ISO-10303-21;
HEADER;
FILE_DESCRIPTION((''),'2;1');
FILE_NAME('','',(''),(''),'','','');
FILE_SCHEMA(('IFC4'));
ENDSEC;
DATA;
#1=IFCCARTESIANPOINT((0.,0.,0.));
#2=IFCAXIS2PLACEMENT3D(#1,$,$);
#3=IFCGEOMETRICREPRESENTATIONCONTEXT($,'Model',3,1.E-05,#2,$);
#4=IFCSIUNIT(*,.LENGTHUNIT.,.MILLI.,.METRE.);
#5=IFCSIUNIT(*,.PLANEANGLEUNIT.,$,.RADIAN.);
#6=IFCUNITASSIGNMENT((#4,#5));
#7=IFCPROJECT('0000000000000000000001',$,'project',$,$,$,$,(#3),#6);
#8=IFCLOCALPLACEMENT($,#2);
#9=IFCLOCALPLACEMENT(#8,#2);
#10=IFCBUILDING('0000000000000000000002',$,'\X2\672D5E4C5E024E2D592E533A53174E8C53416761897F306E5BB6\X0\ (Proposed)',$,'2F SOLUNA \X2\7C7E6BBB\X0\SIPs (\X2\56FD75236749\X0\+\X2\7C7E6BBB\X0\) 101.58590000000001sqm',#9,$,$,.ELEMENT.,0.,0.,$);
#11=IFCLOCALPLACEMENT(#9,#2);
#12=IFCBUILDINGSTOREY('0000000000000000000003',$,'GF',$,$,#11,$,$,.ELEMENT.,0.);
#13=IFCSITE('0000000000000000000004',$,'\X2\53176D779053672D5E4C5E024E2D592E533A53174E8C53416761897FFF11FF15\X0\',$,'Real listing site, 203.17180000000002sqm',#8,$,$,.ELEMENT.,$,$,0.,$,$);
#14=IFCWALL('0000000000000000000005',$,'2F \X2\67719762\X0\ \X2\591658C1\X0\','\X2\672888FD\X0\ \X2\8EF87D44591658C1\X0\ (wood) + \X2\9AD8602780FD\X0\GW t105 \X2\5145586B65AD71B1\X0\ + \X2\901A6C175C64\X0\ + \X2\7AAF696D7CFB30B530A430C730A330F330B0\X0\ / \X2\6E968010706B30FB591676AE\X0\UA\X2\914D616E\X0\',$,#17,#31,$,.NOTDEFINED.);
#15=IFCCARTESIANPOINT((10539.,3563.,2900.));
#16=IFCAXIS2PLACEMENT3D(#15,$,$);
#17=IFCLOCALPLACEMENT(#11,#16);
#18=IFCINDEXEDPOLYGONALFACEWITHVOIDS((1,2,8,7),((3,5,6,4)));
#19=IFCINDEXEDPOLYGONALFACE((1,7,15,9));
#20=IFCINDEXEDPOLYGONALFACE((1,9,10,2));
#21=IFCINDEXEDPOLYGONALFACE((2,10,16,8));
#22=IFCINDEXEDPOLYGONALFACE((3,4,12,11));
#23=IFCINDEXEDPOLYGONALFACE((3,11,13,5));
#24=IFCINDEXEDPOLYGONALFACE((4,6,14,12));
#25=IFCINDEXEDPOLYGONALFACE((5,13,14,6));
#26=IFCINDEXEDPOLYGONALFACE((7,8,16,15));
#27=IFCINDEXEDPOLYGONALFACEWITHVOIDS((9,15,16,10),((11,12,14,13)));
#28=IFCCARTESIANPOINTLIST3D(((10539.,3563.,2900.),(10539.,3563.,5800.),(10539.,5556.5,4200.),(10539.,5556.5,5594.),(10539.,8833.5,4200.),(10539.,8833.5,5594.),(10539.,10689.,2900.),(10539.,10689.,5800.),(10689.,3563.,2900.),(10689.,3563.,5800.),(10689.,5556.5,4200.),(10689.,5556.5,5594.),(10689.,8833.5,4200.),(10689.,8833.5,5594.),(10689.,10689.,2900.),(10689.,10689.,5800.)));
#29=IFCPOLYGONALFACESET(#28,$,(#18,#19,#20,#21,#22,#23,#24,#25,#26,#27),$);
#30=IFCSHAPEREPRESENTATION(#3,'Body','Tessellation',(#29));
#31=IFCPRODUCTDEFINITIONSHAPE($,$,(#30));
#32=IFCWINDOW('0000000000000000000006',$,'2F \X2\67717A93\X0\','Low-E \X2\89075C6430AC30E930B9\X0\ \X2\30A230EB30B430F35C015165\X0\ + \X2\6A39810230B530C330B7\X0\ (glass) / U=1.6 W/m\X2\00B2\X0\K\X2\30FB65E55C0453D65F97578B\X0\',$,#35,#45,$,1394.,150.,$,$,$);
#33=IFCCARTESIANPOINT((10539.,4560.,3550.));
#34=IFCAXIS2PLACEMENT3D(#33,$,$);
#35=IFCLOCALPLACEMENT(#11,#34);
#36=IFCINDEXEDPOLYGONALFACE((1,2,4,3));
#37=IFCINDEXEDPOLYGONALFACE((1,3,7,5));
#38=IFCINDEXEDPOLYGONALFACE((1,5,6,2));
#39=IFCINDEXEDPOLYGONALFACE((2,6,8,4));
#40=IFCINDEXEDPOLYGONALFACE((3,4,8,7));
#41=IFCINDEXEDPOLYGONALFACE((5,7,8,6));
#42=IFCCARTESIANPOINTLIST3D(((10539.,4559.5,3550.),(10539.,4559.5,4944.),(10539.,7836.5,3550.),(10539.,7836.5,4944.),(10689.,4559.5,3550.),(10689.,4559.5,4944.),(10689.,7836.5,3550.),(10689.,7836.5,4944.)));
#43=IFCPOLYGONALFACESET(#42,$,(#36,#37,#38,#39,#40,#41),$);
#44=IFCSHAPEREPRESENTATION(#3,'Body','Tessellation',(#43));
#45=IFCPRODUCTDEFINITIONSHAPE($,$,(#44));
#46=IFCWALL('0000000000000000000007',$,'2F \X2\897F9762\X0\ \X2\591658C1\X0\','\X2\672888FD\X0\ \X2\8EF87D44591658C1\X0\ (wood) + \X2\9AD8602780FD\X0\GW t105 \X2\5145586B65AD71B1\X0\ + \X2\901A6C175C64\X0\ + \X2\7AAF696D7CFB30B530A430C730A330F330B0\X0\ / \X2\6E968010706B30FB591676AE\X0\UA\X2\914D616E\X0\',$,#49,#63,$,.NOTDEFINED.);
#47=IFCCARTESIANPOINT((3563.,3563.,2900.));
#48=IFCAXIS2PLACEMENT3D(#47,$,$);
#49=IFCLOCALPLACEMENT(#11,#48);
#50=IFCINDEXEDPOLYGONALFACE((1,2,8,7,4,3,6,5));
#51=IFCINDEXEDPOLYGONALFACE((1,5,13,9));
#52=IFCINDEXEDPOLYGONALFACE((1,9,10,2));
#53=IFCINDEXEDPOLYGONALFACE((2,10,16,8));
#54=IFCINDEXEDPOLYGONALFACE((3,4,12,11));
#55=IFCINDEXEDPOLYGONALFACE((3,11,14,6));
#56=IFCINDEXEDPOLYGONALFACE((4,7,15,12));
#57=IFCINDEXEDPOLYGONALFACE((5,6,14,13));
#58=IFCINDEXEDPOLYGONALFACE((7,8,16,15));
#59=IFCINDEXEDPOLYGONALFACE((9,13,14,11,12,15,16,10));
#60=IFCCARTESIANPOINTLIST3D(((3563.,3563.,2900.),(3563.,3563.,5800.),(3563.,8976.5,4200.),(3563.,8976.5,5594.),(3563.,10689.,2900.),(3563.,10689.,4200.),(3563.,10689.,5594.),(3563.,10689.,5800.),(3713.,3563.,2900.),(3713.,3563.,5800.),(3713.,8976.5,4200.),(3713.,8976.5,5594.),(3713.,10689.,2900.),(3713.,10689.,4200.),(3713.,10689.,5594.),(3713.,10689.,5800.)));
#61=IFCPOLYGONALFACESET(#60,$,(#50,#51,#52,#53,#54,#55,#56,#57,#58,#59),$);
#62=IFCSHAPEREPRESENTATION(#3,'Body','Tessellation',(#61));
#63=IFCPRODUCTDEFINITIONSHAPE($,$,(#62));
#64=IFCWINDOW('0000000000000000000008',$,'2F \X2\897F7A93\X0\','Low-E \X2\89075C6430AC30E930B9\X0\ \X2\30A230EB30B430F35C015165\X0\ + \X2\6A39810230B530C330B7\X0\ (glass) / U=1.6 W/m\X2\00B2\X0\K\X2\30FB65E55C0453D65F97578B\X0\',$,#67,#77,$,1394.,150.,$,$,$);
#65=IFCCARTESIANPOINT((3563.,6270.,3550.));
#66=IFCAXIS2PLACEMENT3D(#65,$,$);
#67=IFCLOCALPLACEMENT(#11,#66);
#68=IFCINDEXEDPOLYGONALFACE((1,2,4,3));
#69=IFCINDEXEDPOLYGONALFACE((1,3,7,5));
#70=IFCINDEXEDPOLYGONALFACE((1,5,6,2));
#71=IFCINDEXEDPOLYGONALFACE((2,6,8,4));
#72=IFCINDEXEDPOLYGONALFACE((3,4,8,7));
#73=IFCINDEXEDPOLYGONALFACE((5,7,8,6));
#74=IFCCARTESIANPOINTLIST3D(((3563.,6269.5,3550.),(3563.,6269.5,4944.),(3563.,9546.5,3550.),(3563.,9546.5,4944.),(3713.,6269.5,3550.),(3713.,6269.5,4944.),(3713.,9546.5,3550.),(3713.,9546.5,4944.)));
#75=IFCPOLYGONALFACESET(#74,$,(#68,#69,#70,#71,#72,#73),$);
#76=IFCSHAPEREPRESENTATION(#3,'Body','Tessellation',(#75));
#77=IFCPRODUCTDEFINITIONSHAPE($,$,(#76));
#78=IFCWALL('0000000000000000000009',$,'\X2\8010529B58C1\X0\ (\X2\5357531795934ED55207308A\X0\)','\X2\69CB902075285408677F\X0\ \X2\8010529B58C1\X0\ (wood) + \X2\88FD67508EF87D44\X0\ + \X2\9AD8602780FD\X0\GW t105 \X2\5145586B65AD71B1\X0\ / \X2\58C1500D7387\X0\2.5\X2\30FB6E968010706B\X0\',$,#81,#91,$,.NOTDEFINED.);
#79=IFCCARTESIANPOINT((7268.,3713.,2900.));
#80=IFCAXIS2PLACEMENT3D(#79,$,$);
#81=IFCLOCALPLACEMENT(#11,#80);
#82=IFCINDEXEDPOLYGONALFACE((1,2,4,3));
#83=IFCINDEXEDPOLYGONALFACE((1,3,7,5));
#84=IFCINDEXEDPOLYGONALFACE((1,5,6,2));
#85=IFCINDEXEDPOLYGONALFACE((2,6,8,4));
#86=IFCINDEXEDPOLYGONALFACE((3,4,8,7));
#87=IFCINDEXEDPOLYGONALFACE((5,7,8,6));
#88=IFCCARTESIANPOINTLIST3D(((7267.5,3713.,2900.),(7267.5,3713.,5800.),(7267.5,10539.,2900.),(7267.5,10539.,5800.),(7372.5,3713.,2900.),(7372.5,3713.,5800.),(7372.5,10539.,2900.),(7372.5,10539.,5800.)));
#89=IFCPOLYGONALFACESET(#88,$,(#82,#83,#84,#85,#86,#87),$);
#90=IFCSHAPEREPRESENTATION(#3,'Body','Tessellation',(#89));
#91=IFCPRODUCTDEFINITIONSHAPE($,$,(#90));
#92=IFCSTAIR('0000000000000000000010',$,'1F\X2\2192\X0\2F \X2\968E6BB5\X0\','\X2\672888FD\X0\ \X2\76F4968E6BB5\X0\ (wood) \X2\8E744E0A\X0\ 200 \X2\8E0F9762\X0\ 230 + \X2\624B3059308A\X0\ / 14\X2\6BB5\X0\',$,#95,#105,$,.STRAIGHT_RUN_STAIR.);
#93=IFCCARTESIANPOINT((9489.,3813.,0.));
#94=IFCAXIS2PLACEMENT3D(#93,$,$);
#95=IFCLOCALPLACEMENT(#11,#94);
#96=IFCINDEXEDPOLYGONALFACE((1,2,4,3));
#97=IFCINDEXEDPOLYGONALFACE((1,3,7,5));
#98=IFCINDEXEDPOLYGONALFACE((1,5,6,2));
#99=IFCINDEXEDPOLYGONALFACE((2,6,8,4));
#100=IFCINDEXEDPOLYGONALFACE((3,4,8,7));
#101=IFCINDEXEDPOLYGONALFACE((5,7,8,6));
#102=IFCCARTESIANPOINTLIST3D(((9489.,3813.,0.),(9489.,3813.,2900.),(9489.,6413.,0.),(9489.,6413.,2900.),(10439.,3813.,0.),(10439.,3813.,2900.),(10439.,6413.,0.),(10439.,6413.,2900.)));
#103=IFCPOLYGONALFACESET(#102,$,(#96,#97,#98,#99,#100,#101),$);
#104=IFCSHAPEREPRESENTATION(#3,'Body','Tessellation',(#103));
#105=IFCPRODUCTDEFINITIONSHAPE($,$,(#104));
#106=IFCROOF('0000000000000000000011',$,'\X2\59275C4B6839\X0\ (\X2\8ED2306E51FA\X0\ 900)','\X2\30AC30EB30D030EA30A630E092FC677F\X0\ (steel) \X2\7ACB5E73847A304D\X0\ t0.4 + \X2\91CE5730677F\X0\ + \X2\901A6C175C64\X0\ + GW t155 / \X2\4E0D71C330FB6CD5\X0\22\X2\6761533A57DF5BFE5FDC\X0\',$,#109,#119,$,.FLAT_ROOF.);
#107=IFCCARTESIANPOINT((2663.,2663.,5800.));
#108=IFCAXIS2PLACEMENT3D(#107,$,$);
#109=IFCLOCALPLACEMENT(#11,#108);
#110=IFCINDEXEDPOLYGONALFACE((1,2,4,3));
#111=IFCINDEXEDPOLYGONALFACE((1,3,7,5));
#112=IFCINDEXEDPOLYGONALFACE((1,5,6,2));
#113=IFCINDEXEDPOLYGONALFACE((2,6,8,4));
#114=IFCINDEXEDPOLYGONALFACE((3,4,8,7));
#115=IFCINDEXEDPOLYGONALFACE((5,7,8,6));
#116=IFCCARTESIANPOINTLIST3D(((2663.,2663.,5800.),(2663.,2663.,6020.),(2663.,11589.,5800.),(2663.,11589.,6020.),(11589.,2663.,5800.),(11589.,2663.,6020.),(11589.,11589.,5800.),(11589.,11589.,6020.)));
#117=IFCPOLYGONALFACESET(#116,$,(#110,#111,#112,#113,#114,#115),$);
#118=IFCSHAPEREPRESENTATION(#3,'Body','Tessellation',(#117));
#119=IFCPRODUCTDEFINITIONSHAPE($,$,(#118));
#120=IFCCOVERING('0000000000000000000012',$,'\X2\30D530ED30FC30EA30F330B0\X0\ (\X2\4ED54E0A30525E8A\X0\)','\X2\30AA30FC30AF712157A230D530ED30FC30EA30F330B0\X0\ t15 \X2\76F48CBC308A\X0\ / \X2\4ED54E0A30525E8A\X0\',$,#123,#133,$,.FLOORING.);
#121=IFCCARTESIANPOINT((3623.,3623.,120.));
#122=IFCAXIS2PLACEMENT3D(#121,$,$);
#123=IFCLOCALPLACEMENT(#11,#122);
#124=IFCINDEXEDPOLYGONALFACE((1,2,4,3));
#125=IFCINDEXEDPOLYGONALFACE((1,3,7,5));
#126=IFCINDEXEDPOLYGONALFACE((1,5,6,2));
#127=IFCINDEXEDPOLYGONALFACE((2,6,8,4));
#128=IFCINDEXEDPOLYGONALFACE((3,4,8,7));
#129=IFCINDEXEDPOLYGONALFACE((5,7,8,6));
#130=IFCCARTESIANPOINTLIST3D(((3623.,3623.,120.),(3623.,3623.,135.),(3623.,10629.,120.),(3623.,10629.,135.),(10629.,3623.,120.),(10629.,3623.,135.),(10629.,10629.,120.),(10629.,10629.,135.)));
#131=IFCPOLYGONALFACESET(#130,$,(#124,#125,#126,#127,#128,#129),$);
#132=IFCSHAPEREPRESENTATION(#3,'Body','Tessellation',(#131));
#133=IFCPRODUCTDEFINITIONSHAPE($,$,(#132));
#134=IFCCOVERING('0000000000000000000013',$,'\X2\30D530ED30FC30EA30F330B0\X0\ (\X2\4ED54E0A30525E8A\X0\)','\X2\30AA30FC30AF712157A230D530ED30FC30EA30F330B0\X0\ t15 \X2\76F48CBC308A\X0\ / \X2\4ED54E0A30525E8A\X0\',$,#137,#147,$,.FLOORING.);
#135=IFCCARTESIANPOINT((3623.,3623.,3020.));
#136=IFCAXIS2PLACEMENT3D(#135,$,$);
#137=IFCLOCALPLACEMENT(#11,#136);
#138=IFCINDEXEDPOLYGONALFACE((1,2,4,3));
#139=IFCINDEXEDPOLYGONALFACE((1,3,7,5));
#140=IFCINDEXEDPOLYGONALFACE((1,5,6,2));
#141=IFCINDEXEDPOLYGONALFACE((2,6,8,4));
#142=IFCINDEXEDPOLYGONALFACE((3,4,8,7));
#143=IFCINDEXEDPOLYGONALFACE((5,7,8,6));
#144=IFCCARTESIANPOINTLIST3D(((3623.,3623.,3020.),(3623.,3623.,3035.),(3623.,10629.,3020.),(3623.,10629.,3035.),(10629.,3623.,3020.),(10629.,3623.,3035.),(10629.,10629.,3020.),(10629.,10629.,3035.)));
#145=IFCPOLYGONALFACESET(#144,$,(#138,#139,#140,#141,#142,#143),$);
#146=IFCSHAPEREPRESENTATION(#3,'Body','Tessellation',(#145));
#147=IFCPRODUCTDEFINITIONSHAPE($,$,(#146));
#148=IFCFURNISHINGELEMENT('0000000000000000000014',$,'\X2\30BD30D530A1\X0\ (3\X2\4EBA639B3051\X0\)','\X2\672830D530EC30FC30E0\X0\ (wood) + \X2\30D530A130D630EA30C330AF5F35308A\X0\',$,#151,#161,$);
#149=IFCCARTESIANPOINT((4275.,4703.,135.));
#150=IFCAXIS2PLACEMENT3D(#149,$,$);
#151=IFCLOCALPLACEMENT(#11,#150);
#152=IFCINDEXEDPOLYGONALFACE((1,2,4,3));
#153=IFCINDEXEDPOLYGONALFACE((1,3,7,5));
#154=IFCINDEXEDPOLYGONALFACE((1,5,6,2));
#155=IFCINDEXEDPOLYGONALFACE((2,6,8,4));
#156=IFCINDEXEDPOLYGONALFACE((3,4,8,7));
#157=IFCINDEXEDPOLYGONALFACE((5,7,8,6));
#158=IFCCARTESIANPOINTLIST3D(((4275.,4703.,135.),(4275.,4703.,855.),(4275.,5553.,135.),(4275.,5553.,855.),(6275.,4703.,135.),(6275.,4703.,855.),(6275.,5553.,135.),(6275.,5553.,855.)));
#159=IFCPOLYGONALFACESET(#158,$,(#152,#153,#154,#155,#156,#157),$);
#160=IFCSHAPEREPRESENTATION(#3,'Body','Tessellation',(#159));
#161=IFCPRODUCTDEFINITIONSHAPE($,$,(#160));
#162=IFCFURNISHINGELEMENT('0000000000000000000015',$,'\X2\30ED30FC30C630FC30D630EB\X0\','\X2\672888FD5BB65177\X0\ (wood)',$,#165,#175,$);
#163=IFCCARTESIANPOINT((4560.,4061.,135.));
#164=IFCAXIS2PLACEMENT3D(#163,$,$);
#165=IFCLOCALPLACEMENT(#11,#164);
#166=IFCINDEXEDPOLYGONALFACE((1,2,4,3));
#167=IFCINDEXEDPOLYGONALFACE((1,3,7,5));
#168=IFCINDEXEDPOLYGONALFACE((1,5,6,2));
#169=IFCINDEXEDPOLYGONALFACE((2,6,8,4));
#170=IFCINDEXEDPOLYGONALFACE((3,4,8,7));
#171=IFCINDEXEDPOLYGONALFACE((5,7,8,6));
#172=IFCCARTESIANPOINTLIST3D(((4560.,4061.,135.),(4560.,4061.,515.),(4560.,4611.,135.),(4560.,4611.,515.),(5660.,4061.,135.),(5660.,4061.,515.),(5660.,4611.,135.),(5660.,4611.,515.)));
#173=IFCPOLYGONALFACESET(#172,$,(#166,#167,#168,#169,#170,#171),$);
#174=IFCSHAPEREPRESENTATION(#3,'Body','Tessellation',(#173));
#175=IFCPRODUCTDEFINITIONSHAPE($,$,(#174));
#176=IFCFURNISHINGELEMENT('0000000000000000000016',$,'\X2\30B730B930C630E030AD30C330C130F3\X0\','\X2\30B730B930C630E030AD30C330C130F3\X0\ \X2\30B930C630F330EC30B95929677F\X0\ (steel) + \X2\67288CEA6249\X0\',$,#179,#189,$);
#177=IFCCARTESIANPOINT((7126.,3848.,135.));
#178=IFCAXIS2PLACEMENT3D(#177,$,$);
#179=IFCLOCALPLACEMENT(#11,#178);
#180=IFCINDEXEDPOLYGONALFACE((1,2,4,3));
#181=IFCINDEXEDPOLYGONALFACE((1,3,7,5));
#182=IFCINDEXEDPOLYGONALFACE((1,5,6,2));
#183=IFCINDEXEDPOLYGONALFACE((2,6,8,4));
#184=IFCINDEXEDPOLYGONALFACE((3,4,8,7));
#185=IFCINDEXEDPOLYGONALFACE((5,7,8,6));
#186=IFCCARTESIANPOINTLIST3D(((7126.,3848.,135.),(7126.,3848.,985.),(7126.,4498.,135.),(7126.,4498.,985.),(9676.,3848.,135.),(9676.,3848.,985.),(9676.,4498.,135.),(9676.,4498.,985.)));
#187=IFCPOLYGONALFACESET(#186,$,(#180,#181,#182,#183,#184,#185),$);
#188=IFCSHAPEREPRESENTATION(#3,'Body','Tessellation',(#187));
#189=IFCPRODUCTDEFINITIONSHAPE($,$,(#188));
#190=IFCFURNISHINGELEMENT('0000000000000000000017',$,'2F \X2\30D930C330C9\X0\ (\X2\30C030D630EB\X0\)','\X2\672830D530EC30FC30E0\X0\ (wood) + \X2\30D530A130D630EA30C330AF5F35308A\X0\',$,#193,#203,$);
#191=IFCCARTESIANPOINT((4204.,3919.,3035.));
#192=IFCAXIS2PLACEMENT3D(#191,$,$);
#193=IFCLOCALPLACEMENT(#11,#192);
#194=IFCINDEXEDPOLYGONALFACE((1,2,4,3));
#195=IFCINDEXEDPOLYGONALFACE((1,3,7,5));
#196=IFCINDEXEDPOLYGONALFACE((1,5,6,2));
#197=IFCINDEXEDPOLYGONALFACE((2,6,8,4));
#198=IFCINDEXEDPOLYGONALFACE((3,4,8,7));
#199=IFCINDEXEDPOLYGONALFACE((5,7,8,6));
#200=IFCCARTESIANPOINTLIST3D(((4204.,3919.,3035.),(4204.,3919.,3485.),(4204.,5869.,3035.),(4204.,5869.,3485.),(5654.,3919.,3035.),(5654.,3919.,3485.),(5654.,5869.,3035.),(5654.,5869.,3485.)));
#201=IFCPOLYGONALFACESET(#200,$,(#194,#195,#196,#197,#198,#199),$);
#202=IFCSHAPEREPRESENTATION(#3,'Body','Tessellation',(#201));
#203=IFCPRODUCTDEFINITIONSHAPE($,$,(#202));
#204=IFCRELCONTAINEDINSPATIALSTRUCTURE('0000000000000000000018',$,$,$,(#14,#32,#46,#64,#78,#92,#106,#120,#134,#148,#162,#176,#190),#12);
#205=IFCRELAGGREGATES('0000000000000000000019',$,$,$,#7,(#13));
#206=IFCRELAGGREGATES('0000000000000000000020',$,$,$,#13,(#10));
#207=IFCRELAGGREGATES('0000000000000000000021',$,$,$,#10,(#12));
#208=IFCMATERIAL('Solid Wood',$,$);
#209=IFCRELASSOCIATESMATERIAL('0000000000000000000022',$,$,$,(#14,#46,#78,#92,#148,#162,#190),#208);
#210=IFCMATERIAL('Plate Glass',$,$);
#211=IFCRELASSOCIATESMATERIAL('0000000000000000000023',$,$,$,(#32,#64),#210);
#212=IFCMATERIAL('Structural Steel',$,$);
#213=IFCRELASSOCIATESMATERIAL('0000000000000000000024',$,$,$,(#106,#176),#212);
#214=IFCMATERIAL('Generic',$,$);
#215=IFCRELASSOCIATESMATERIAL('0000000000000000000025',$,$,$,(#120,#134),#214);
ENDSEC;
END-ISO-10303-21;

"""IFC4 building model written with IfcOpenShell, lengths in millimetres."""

from ifc_helpers import new_model, si_unit, frame, frame_2d, origin, place, context, project, spatial, rectangle, extrude, material, element, fill, save


model = new_model("IFC4")

# Units and contexts
model_context = context("Model", 3, precision=1e-05, world=origin())
ifc_project = project(units=[si_unit("LENGTHUNIT", "METRE", prefix="MILLI"), si_unit("PLANEANGLEUNIT", "RADIAN")], contexts=[model_context])

# Site, building, storey
site_placement = place(None, origin())
site = spatial("IfcSite", under=ifc_project, at=site_placement, Name="北海道札幌市中央区北二十条西１５", ObjectType="Real listing site, 203.17180000000002sqm", CompositionType="ELEMENT", RefElevation=0.0)
building_placement = place(site_placement, origin())
building = spatial("IfcBuilding", under=site, at=building_placement, Name="札幌市中央区北二十条西の家 (Proposed)", ObjectType="2F SOLUNA 籾殻SIPs (国産杉+籾殻) 101.58590000000001sqm", CompositionType="ELEMENT", ElevationOfRefHeight=0.0, ElevationOfTerrain=0.0)
storey_placement = place(building_placement, origin())
storey = spatial("IfcBuildingStorey", under=building, at=storey_placement, Name="GF", CompositionType="ELEMENT", Elevation=0.0)

# Shared definitions
ifc_material_1 = material(Name="Solid Wood")

# Shared definitions
ifc_material_2 = material(Name="Plate Glass")

# Walls, openings, windows
wall_1_placement = place(storey_placement, frame((10539.0, 3563.0, 2900.0)))
wall_1 = element("IfcWall", 1, at=wall_1_placement, inside=storey, material=ifc_material_1, Name="2F 東面 外壁", Description="木製 軸組外壁 (wood) + 高性能GW t105 充填断熱 + 通気層 + 窯業系サイディング / 準耐火・外皮UA配慮", PredefinedType="NOTDEFINED", context=model_context, shape_type="SweptSolid", body=[
    extrude(rectangle(XDim=150.0, YDim=7126.0, at=frame_2d((75.0, 3563.0))), frame((10539.0, 3563.0, 2900.0)), (0.0, 0.0, 1.0), 2900.0),
])
opening_1_placement = place(storey_placement, frame((10539.0, 4560.0, 3550.0)))
opening_1 = element("IfcOpeningElement", 2, at=opening_1_placement, cuts=wall_1, PredefinedType="NOTDEFINED", context=model_context, shape_type="SweptSolid", body=[
    extrude(rectangle(XDim=150.0, YDim=3277.0, at=frame_2d((75.0, 1638.0))), frame((10539.0, 4560.0, 3550.0)), (0.0, 0.0, 1.0), 1394.0),
])
window_1_placement = place(storey_placement, frame((10539.0, 4560.0, 3550.0)))
window_1 = element("IfcWindow", 3, at=window_1_placement, inside=storey, material=ifc_material_2, Name="2F 東窓", Description="Low-E 複層ガラス アルゴン封入 + 樹脂サッシ (glass) / U=1.6 W/m²K・日射取得型", OverallHeight=1394.0, OverallWidth=150.0, context=model_context, shape_type="SweptSolid", body=[
    extrude(rectangle(XDim=150.0, YDim=3277.0, at=frame_2d((75.0, 1638.0))), frame((10539.0, 4560.0, 3550.0)), (0.0, 0.0, 1.0), 1394.0),
])
fill(opening_1, window_1)
wall_2_placement = place(storey_placement, frame((3563.0, 3563.0, 2900.0)))
wall_2 = element("IfcWall", 4, at=wall_2_placement, inside=storey, material=ifc_material_1, Name="2F 西面 外壁", Description="木製 軸組外壁 (wood) + 高性能GW t105 充填断熱 + 通気層 + 窯業系サイディング / 準耐火・外皮UA配慮", PredefinedType="NOTDEFINED", context=model_context, shape_type="SweptSolid", body=[
    extrude(rectangle(XDim=150.0, YDim=7126.0, at=frame_2d((75.0, 3563.0))), frame((3563.0, 3563.0, 2900.0)), (0.0, 0.0, 1.0), 2900.0),
])
opening_2_placement = place(storey_placement, frame((3563.0, 6270.0, 3550.0)))
opening_2 = element("IfcOpeningElement", 5, at=opening_2_placement, cuts=wall_2, PredefinedType="NOTDEFINED", context=model_context, shape_type="SweptSolid", body=[
    extrude(rectangle(XDim=150.0, YDim=3277.0, at=frame_2d((75.0, 1638.0))), frame((3563.0, 6270.0, 3550.0)), (0.0, 0.0, 1.0), 1394.0),
])
window_2_placement = place(storey_placement, frame((3563.0, 6270.0, 3550.0)))
window_2 = element("IfcWindow", 6, at=window_2_placement, inside=storey, material=ifc_material_2, Name="2F 西窓", Description="Low-E 複層ガラス アルゴン封入 + 樹脂サッシ (glass) / U=1.6 W/m²K・日射取得型", OverallHeight=1394.0, OverallWidth=150.0, context=model_context, shape_type="SweptSolid", body=[
    extrude(rectangle(XDim=150.0, YDim=3277.0, at=frame_2d((75.0, 1638.0))), frame((3563.0, 6270.0, 3550.0)), (0.0, 0.0, 1.0), 1394.0),
])
fill(opening_2, window_2)

# Wall
wall_3_placement = place(storey_placement, frame((7268.0, 3713.0, 2900.0)))
element("IfcWall", 7, at=wall_3_placement, inside=storey, material=ifc_material_1, Name="耐力壁 (南北間仕切り)", Description="構造用合板 耐力壁 (wood) + 製材軸組 + 高性能GW t105 充填断熱 / 壁倍率2.5・準耐火", PredefinedType="NOTDEFINED", context=model_context, shape_type="SweptSolid", body=[
    extrude(rectangle(XDim=105.0, YDim=6826.0, at=frame_2d((52.0, 3413.0))), frame((7268.0, 3713.0, 2900.0)), (0.0, 0.0, 1.0), 2900.0),
])

# Stair
stair_placement = place(storey_placement, frame((9489.0, 3813.0, 0.0)))
element("IfcStair", 8, at=stair_placement, inside=storey, material=ifc_material_1, Name="1F→2F 階段", Description="木製 直階段 (wood) 蹴上 200 踏面 230 + 手すり / 14段", PredefinedType="STRAIGHT_RUN_STAIR", context=model_context, shape_type="SweptSolid", body=[
    extrude(rectangle(XDim=950.0, YDim=2600.0, at=frame_2d((475.0, 1300.0))), frame((9489.0, 3813.0, 0.0)), (0.0, 0.0, 1.0), 2900.0),
])

# Roof
ifc_material_3 = material(Name="Structural Steel")
roof_placement = place(storey_placement, frame((2663.0, 2663.0, 5800.0)))
element("IfcRoof", 9, at=roof_placement, inside=storey, material=ifc_material_3, Name="大屋根 (軒の出 900)", Description="ガルバリウム鋼板 (steel) 立平葺き t0.4 + 野地板 + 通気層 + GW t155 / 不燃・法22条区域対応", PredefinedType="FLAT_ROOF", context=model_context, shape_type="SweptSolid", body=[
    extrude(rectangle(XDim=8926.0, YDim=8926.0, at=frame_2d((4463.0, 4463.0))), frame((2663.0, 2663.0, 5800.0)), (0.0, 0.0, 1.0), 220.0),
])

# Coverings
ifc_material_4 = material(Name="Generic")
covering_1_placement = place(storey_placement, frame((3623.0, 3623.0, 120.0)))
element("IfcCovering", 10, at=covering_1_placement, inside=storey, material=ifc_material_4, Name="フローリング (仕上げ床)", Description="オーク無垢フローリング t15 直貼り / 仕上げ床", PredefinedType="FLOORING", context=model_context, shape_type="SweptSolid", body=[
    extrude(rectangle(XDim=7006.0, YDim=7006.0, at=frame_2d((3503.0, 3503.0))), frame((3623.0, 3623.0, 120.0)), (0.0, 0.0, 1.0), 15.0),
])
covering_2_placement = place(storey_placement, frame((3623.0, 3623.0, 3020.0)))
element("IfcCovering", 11, at=covering_2_placement, inside=storey, material=ifc_material_4, Name="フローリング (仕上げ床)", Description="オーク無垢フローリング t15 直貼り / 仕上げ床", PredefinedType="FLOORING", context=model_context, shape_type="SweptSolid", body=[
    extrude(rectangle(XDim=7006.0, YDim=7006.0, at=frame_2d((3503.0, 3503.0))), frame((3623.0, 3623.0, 3020.0)), (0.0, 0.0, 1.0), 15.0),
])

# Furnishing elements
furnishing_1_placement = place(storey_placement, frame((4275.0, 4703.0, 135.0)))
element("IfcFurnishingElement", 12, at=furnishing_1_placement, inside=storey, material=ifc_material_1, Name="ソファ (3人掛け)", Description="木フレーム (wood) + ファブリック張り", context=model_context, shape_type="SweptSolid", body=[
    extrude(rectangle(XDim=2000.0, YDim=850.0, at=frame_2d((1000.0, 425.0))), frame((4275.0, 4703.0, 135.0)), (0.0, 0.0, 1.0), 720.0),
])
furnishing_2_placement = place(storey_placement, frame((4560.0, 4061.0, 135.0)))
element("IfcFurnishingElement", 13, at=furnishing_2_placement, inside=storey, material=ifc_material_1, Name="ローテーブル", Description="木製家具 (wood)", context=model_context, shape_type="SweptSolid", body=[
    extrude(rectangle(XDim=1100.0, YDim=550.0, at=frame_2d((550.0, 275.0))), frame((4560.0, 4061.0, 135.0)), (0.0, 0.0, 1.0), 380.0),
])
furnishing_3_placement = place(storey_placement, frame((7126.0, 3848.0, 135.0)))
element("IfcFurnishingElement", 14, at=furnishing_3_placement, inside=storey, material=ifc_material_3, Name="システムキッチン", Description="システムキッチン ステンレス天板 (steel) + 木質扉", context=model_context, shape_type="SweptSolid", body=[
    extrude(rectangle(XDim=2550.0, YDim=650.0, at=frame_2d((1275.0, 325.0))), frame((7126.0, 3848.0, 135.0)), (0.0, 0.0, 1.0), 850.0),
])
furnishing_4_placement = place(storey_placement, frame((4204.0, 3919.0, 3035.0)))
element("IfcFurnishingElement", 15, at=furnishing_4_placement, inside=storey, material=ifc_material_1, Name="2F ベッド (ダブル)", Description="木フレーム (wood) + ファブリック張り", context=model_context, shape_type="SweptSolid", body=[
    extrude(rectangle(XDim=1450.0, YDim=1950.0, at=frame_2d((725.0, 975.0))), frame((4204.0, 3919.0, 3035.0)), (0.0, 0.0, 1.0), 450.0),
])

save(model, "model.ifc")
